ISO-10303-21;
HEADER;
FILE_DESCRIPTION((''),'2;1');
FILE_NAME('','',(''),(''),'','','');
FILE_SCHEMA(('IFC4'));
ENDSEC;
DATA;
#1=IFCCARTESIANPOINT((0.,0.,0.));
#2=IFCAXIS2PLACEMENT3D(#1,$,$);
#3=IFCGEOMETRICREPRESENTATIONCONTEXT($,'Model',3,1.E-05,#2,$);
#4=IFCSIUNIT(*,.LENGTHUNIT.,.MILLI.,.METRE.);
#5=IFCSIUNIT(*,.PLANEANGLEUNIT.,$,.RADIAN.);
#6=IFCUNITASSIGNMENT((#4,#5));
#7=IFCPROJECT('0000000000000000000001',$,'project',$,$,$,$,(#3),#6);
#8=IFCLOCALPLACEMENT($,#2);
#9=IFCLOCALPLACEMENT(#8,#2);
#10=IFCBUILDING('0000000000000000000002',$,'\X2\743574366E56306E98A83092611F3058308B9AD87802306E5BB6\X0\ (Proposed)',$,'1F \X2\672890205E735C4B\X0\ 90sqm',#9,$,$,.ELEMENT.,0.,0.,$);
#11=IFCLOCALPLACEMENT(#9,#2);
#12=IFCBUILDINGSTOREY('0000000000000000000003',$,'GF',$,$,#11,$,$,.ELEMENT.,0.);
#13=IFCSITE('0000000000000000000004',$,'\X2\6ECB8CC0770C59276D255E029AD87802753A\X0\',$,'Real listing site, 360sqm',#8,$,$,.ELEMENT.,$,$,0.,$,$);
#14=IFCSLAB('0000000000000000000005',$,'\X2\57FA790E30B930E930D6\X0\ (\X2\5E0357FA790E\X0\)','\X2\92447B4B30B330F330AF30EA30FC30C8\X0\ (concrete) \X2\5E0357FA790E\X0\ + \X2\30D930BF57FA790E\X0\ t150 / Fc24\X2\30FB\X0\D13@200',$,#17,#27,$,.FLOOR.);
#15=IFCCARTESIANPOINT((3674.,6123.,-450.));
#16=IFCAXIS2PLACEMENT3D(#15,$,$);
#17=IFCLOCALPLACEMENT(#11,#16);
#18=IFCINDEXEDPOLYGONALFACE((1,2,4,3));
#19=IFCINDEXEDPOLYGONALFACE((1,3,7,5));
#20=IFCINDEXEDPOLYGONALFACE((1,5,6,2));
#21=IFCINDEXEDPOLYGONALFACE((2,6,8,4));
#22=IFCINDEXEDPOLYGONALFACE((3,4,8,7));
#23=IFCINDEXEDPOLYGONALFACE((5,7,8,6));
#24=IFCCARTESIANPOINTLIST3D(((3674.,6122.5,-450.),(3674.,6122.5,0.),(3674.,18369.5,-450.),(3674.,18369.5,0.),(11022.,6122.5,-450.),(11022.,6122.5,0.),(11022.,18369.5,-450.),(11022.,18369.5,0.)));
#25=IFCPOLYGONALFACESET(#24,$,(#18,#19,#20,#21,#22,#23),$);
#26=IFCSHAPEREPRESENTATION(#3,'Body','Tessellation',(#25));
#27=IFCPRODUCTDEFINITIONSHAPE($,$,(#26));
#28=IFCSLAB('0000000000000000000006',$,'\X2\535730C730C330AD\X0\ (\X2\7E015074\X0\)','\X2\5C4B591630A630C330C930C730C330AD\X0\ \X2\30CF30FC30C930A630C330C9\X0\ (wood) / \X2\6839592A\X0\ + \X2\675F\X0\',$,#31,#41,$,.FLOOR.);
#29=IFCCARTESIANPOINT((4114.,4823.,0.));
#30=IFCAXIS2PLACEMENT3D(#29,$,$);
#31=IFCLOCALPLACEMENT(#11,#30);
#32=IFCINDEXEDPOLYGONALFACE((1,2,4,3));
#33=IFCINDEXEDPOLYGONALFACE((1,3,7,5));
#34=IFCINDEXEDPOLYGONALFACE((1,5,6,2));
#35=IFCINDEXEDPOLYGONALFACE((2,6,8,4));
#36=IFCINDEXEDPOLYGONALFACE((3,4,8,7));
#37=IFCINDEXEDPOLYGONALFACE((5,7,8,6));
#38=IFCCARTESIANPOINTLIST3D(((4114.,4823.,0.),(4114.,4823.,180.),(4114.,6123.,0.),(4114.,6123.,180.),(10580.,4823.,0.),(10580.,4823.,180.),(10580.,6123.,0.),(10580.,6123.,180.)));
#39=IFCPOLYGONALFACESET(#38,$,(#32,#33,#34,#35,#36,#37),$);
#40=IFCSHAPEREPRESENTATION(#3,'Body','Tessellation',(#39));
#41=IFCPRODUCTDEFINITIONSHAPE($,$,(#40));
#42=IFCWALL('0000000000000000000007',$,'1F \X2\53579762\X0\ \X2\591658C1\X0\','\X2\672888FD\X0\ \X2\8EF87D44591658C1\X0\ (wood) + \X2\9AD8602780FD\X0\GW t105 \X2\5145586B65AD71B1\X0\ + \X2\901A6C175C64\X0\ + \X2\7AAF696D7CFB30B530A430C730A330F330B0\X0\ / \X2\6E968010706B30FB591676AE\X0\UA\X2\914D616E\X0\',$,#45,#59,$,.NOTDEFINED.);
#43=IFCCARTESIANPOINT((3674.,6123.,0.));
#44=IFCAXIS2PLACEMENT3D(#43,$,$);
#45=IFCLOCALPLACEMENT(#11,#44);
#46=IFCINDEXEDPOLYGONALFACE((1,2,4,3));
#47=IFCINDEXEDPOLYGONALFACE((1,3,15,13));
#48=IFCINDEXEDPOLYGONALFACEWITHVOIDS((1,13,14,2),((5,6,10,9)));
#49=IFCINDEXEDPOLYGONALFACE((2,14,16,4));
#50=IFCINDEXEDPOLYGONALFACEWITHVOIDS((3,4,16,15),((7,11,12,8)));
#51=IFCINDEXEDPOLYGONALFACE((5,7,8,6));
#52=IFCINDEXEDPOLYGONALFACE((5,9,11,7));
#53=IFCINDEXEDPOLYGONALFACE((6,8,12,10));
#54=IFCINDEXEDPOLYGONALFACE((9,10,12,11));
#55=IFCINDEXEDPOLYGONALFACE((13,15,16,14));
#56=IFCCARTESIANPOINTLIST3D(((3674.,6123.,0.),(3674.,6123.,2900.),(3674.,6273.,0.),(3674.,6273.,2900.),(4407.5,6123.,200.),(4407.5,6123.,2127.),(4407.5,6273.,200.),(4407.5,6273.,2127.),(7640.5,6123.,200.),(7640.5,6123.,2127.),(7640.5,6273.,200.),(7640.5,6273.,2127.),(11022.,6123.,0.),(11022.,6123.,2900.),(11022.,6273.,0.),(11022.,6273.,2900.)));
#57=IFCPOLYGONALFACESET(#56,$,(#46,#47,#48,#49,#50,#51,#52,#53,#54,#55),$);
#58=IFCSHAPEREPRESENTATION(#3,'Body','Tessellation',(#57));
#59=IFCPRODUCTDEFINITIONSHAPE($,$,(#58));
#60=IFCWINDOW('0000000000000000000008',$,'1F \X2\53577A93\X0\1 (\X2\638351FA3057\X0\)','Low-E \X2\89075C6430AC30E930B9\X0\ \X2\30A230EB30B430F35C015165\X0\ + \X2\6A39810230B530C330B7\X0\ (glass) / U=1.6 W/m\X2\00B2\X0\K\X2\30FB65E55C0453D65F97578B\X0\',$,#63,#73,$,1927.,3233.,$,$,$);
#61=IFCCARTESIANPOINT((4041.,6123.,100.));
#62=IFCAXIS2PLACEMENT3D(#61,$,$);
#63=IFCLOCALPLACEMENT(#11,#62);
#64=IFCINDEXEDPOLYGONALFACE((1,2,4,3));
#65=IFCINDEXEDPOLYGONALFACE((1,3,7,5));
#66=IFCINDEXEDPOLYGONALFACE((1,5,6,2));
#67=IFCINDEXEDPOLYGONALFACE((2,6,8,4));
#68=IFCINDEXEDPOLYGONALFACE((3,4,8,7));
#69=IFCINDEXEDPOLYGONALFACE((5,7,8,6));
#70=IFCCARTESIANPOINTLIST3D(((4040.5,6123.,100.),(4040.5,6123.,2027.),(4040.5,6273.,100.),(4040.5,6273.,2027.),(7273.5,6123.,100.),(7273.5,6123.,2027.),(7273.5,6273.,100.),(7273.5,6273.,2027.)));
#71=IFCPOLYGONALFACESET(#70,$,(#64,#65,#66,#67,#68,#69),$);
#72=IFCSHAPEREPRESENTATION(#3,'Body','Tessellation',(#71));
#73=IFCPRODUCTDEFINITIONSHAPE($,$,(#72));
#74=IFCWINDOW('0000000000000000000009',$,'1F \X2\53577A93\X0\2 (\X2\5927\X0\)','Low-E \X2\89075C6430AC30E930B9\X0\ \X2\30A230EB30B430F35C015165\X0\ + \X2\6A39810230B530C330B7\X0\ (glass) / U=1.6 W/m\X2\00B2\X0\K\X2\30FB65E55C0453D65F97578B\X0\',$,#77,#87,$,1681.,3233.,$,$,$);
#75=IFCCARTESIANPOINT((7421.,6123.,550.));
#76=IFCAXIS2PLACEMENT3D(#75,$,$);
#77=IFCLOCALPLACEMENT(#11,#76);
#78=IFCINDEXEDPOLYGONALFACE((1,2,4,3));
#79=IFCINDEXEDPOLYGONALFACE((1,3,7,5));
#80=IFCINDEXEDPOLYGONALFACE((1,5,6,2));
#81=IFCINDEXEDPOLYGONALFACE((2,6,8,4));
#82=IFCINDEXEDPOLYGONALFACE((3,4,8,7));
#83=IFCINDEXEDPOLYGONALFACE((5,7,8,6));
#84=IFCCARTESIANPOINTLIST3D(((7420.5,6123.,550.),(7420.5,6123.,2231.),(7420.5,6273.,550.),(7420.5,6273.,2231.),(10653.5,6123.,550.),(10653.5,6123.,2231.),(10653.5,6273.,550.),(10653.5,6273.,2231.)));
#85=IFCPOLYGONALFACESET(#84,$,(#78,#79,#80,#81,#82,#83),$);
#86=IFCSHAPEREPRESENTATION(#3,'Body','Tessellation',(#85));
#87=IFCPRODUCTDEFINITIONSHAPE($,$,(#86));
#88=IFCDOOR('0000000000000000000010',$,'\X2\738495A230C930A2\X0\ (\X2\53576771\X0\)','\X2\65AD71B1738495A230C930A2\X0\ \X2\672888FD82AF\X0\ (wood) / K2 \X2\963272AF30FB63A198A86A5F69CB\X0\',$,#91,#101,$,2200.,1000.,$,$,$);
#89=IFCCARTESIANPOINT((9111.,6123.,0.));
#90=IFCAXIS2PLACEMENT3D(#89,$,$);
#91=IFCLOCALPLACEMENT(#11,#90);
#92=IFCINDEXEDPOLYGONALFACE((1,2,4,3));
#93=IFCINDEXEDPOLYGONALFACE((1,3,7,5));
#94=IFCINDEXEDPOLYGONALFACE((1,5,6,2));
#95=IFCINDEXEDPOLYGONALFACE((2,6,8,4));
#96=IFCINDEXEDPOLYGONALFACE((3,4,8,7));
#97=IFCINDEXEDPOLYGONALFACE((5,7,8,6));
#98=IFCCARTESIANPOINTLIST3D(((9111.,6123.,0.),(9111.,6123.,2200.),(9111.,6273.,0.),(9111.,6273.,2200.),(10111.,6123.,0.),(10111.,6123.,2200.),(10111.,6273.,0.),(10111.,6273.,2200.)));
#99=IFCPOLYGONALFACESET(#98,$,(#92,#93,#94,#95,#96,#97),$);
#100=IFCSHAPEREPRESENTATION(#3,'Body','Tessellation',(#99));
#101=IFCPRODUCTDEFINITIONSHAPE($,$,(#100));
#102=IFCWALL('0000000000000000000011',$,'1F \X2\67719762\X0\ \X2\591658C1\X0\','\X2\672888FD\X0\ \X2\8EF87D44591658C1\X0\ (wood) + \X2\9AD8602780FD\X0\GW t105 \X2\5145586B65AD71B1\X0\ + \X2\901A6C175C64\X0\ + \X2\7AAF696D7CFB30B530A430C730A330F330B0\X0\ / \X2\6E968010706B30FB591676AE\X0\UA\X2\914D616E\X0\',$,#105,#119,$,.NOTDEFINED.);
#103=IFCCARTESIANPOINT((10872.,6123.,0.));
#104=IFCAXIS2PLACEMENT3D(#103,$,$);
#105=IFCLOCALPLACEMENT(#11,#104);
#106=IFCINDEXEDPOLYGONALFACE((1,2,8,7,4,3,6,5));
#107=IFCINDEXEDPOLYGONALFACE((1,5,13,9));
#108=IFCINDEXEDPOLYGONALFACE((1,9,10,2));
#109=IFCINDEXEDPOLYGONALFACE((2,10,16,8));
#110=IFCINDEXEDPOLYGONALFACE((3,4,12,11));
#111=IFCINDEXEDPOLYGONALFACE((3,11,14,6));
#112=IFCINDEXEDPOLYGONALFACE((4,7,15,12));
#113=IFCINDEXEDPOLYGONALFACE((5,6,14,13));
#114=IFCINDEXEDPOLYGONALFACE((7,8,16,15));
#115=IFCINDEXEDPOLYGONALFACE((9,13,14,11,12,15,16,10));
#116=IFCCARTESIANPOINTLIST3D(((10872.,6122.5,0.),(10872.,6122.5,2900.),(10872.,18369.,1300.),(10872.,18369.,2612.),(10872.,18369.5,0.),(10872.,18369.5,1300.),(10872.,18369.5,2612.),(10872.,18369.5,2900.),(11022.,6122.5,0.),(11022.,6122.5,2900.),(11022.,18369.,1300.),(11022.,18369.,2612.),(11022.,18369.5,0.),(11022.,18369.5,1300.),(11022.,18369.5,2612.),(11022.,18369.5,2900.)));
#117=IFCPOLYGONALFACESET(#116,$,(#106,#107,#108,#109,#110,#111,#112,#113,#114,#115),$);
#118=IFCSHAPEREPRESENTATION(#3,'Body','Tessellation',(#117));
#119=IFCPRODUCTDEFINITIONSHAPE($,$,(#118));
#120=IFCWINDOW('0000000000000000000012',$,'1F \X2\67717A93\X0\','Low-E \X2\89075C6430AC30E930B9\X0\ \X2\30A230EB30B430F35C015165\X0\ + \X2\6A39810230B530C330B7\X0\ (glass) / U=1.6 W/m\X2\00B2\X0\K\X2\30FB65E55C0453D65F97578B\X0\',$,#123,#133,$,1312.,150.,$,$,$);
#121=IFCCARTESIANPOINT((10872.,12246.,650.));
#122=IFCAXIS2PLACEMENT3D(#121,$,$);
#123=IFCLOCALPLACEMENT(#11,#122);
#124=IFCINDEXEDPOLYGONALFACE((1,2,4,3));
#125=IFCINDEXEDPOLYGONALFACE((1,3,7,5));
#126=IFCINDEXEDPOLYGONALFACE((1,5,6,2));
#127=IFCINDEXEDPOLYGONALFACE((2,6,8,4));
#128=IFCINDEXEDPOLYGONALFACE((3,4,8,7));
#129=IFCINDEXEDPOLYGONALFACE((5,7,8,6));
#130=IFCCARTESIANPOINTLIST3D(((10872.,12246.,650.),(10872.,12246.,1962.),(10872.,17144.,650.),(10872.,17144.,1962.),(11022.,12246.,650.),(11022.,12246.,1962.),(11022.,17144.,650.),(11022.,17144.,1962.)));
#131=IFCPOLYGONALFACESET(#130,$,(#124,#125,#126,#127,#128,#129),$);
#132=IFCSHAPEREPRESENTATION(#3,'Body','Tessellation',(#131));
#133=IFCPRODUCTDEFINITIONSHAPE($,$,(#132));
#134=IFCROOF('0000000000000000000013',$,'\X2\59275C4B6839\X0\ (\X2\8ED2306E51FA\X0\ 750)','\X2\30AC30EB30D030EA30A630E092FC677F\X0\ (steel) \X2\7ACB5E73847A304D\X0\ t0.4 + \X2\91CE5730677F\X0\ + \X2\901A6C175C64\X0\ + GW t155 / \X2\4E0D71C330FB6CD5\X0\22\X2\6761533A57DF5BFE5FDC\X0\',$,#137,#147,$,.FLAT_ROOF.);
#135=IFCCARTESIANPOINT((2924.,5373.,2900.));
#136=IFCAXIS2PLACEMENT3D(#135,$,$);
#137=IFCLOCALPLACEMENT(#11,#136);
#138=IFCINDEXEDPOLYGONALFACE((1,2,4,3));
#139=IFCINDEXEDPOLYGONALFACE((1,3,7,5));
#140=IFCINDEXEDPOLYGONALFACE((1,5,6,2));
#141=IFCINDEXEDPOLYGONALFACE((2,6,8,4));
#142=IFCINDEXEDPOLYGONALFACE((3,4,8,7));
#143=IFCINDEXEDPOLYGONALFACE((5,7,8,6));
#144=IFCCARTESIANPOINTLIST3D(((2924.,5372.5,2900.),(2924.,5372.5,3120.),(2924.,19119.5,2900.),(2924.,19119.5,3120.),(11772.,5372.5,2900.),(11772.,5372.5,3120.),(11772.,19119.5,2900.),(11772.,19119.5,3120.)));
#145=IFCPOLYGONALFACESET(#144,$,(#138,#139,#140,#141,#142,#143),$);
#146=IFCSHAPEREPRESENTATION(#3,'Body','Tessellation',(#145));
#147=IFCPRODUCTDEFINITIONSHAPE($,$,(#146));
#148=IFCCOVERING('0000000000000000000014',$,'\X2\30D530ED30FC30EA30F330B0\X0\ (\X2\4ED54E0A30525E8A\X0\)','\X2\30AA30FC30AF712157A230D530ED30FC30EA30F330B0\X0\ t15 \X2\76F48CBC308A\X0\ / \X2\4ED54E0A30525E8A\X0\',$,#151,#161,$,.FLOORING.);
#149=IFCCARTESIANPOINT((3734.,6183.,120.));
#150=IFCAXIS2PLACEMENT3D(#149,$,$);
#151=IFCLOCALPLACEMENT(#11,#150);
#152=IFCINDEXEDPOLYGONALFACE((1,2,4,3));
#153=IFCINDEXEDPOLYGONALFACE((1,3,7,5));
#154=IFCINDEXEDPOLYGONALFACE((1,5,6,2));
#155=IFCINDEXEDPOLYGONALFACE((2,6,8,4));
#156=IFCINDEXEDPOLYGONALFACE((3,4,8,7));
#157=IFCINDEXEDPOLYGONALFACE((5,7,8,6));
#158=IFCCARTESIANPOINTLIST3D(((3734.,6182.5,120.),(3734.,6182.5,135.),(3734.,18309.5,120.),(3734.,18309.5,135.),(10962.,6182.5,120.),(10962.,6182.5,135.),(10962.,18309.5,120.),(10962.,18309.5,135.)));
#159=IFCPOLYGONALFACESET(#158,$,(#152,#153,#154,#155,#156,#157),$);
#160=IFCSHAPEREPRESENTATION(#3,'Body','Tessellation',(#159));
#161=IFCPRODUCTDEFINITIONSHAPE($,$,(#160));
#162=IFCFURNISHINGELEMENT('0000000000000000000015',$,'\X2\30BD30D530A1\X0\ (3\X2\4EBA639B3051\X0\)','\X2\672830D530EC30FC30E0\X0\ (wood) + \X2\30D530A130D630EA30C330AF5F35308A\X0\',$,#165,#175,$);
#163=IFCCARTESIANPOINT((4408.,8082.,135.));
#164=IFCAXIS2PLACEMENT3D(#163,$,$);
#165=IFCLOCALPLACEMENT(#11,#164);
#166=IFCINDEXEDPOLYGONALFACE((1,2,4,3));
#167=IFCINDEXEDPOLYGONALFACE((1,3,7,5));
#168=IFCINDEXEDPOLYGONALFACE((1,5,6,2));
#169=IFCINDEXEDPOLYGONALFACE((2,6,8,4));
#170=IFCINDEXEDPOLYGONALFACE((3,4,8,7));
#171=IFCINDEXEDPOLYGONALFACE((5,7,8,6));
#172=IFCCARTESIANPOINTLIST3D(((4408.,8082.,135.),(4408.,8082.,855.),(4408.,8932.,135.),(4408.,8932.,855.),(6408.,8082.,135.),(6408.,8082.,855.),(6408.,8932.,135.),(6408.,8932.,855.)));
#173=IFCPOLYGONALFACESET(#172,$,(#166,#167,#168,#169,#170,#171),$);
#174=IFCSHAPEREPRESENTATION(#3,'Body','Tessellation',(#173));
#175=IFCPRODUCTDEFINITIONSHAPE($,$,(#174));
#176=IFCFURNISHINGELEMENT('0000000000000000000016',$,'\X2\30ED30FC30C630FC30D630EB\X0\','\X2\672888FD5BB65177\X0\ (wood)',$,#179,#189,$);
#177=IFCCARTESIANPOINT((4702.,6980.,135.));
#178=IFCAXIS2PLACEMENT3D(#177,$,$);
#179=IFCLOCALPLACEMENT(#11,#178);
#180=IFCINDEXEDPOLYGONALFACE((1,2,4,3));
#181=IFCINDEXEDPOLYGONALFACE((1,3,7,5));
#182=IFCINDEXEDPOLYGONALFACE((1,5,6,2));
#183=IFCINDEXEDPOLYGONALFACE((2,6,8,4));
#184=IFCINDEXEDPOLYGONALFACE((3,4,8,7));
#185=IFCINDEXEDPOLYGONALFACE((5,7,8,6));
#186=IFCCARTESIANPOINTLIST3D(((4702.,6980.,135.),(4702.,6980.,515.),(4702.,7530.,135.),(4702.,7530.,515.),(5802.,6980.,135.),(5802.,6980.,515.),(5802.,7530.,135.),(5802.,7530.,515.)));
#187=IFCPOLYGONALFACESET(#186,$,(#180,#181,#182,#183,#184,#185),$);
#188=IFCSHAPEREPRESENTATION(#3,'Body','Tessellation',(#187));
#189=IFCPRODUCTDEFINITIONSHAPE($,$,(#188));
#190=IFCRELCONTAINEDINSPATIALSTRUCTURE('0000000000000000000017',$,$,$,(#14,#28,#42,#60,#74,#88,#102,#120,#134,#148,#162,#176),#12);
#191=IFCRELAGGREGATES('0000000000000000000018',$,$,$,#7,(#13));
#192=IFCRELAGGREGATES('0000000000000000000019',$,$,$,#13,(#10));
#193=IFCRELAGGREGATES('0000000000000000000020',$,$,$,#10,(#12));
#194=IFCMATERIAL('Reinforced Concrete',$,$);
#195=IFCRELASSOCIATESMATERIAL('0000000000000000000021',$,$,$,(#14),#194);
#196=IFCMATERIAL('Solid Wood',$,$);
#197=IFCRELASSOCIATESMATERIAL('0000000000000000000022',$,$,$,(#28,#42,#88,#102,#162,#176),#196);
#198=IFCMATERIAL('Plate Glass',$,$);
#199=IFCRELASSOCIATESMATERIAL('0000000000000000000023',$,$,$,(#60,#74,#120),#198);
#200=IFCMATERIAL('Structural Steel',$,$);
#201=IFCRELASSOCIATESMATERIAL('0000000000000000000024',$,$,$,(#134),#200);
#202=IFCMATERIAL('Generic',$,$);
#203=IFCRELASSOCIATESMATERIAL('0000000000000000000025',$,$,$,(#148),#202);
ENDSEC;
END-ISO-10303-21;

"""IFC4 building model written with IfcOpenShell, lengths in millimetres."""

from ifc_helpers import new_model, si_unit, frame, frame_2d, origin, place, context, project, spatial, rectangle, extrude, material, element, fill, save


model = new_model("IFC4")

# Units and contexts
model_context = context("Model", 3, precision=1e-05, world=origin())
ifc_project = project(units=[si_unit("LENGTHUNIT", "METRE", prefix="MILLI"), si_unit("PLANEANGLEUNIT", "RADIAN")], contexts=[model_context])

# Site, building, storey
site_placement = place(None, origin())
site = spatial("IfcSite", under=ifc_project, at=site_placement, Name="滋賀県大津市高砂町", ObjectType="Real listing site, 360sqm", CompositionType="ELEMENT", RefElevation=0.0)
building_placement = place(site_placement, origin())
building = spatial("IfcBuilding", under=site, at=building_placement, Name="琵琶湖の風を感じる高砂の家 (Proposed)", ObjectType="1F 木造平屋 90sqm", CompositionType="ELEMENT", ElevationOfRefHeight=0.0, ElevationOfTerrain=0.0)
storey_placement = place(building_placement, origin())
storey = spatial("IfcBuildingStorey", under=building, at=storey_placement, Name="GF", CompositionType="ELEMENT", Elevation=0.0)

# Slabs
ifc_material_1 = material(Name="Reinforced Concrete")
slab_1_placement = place(storey_placement, frame((3674.0, 6123.0, -450.0)))
element("IfcSlab", 1, at=slab_1_placement, inside=storey, material=ifc_material_1, Name="基礎スラブ (布基礎)", Description="鉄筋コンクリート (concrete) 布基礎 + ベタ基礎 t150 / Fc24・D13@200", PredefinedType="FLOOR", context=model_context, shape_type="SweptSolid", body=[
    extrude(rectangle(XDim=7348.0, YDim=12247.0, at=frame_2d((3674.0, 6123.0))), frame((3674.0, 6123.0, -450.0)), (0.0, 0.0, 1.0), 450.0),
])
ifc_material_2 = material(Name="Solid Wood")
slab_2_placement = place(storey_placement, frame((4114.0, 4823.0, 0.0)))
element("IfcSlab", 2, at=slab_2_placement, inside=storey, material=ifc_material_2, Name="南デッキ (縁側)", Description="屋外ウッドデッキ ハードウッド (wood) / 根太 + 束", PredefinedType="FLOOR", context=model_context, shape_type="SweptSolid", body=[
    extrude(rectangle(XDim=6466.0, YDim=1300.0, at=frame_2d((3233.0, 650.0))), frame((4114.0, 4823.0, 0.0)), (0.0, 0.0, 1.0), 180.0),
])

# Wall, openings, windows, door
wall_1_placement = place(storey_placement, frame((3674.0, 6123.0, 0.0)))
wall_1 = element("IfcWall", 3, at=wall_1_placement, inside=storey, material=ifc_material_2, Name="1F 南面 外壁", Description="木製 軸組外壁 (wood) + 高性能GW t105 充填断熱 + 通気層 + 窯業系サイディング / 準耐火・外皮UA配慮", PredefinedType="NOTDEFINED", context=model_context, shape_type="SweptSolid", body=[
    extrude(rectangle(XDim=7348.0, YDim=150.0, at=frame_2d((3674.0, 75.0))), frame((3674.0, 6123.0, 0.0)), (0.0, 0.0, 1.0), 2900.0),
])
opening_1_placement = place(storey_placement, frame((4041.0, 6123.0, 100.0)))
opening_1 = element("IfcOpeningElement", 4, at=opening_1_placement, cuts=wall_1, PredefinedType="NOTDEFINED", context=model_context, shape_type="SweptSolid", body=[
    extrude(rectangle(XDim=3233.0, YDim=150.0, at=frame_2d((1616.0, 75.0))), frame((4041.0, 6123.0, 100.0)), (0.0, 0.0, 1.0), 1927.0),
])
opening_2_placement = place(storey_placement, frame((7421.0, 6123.0, 550.0)))
opening_2 = element("IfcOpeningElement", 5, at=opening_2_placement, cuts=wall_1, PredefinedType="NOTDEFINED", context=model_context, shape_type="SweptSolid", body=[
    extrude(rectangle(XDim=3233.0, YDim=150.0, at=frame_2d((1616.0, 75.0))), frame((7421.0, 6123.0, 550.0)), (0.0, 0.0, 1.0), 1681.0),
])
opening_3_placement = place(storey_placement, frame((9111.0, 6123.0, 0.0)))
opening_3 = element("IfcOpeningElement", 6, at=opening_3_placement, cuts=wall_1, PredefinedType="NOTDEFINED", context=model_context, shape_type="SweptSolid", body=[
    extrude(rectangle(XDim=1000.0, YDim=150.0, at=frame_2d((500.0, 75.0))), frame((9111.0, 6123.0, 0.0)), (0.0, 0.0, 1.0), 2200.0),
])
ifc_material_3 = material(Name="Plate Glass")
window_1_placement = place(storey_placement, frame((4041.0, 6123.0, 100.0)))
window_1 = element("IfcWindow", 7, at=window_1_placement, inside=storey, material=ifc_material_3, Name="1F 南窓1 (掃出し)", Description="Low-E 複層ガラス アルゴン封入 + 樹脂サッシ (glass) / U=1.6 W/m²K・日射取得型", OverallHeight=1927.0, OverallWidth=3233.0, context=model_context, shape_type="SweptSolid", body=[
    extrude(rectangle(XDim=3233.0, YDim=150.0, at=frame_2d((1616.0, 75.0))), frame((4041.0, 6123.0, 100.0)), (0.0, 0.0, 1.0), 1927.0),
])
fill(opening_1, window_1)
window_2_placement = place(storey_placement, frame((7421.0, 6123.0, 550.0)))
window_2 = element("IfcWindow", 8, at=window_2_placement, inside=storey, material=ifc_material_3, Name="1F 南窓2 (大)", Description="Low-E 複層ガラス アルゴン封入 + 樹脂サッシ (glass) / U=1.6 W/m²K・日射取得型", OverallHeight=1681.0, OverallWidth=3233.0, context=model_context, shape_type="SweptSolid", body=[
    extrude(rectangle(XDim=3233.0, YDim=150.0, at=frame_2d((1616.0, 75.0))), frame((7421.0, 6123.0, 550.0)), (0.0, 0.0, 1.0), 1681.0),
])
fill(opening_2, window_2)
door_placement = place(storey_placement, frame((9111.0, 6123.0, 0.0)))
door = element("IfcDoor", 9, at=door_placement, inside=storey, material=ifc_material_2, Name="玄関ドア (南東)", Description="断熱玄関ドア 木製芯 (wood) / K2 防犯・採風機構", OverallHeight=2200.0, OverallWidth=1000.0, context=model_context, shape_type="SweptSolid", body=[
    extrude(rectangle(XDim=1000.0, YDim=150.0, at=frame_2d((500.0, 75.0))), frame((9111.0, 6123.0, 0.0)), (0.0, 0.0, 1.0), 2200.0),
])
fill(opening_3, door)

# Wall, opening, window
wall_2_placement = place(storey_placement, frame((10872.0, 6123.0, 0.0)))
wall_2 = element("IfcWall", 10, at=wall_2_placement, inside=storey, material=ifc_material_2, Name="1F 東面 外壁", Description="木製 軸組外壁 (wood) + 高性能GW t105 充填断熱 + 通気層 + 窯業系サイディング / 準耐火・外皮UA配慮", PredefinedType="NOTDEFINED", context=model_context, shape_type="SweptSolid", body=[
    extrude(rectangle(XDim=150.0, YDim=12247.0, at=frame_2d((75.0, 6123.0))), frame((10872.0, 6123.0, 0.0)), (0.0, 0.0, 1.0), 2900.0),
])
opening_4_placement = place(storey_placement, frame((10872.0, 12246.0, 650.0)))
opening_4 = element("IfcOpeningElement", 11, at=opening_4_placement, cuts=wall_2, PredefinedType="NOTDEFINED", context=model_context, shape_type="SweptSolid", body=[
    extrude(rectangle(XDim=150.0, YDim=4898.0, at=frame_2d((75.0, 2449.0))), frame((10872.0, 12246.0, 650.0)), (0.0, 0.0, 1.0), 1312.0),
])
window_3_placement = place(storey_placement, frame((10872.0, 12246.0, 650.0)))
window_3 = element("IfcWindow", 12, at=window_3_placement, inside=storey, material=ifc_material_3, Name="1F 東窓", Description="Low-E 複層ガラス アルゴン封入 + 樹脂サッシ (glass) / U=1.6 W/m²K・日射取得型", OverallHeight=1312.0, OverallWidth=150.0, context=model_context, shape_type="SweptSolid", body=[
    extrude(rectangle(XDim=150.0, YDim=4898.0, at=frame_2d((75.0, 2449.0))), frame((10872.0, 12246.0, 650.0)), (0.0, 0.0, 1.0), 1312.0),
])
fill(opening_4, window_3)

# Roof
ifc_material_4 = material(Name="Structural Steel")
roof_placement = place(storey_placement, frame((2924.0, 5373.0, 2900.0)))
element("IfcRoof", 13, at=roof_placement, inside=storey, material=ifc_material_4, Name="大屋根 (軒の出 750)", Description="ガルバリウム鋼板 (steel) 立平葺き t0.4 + 野地板 + 通気層 + GW t155 / 不燃・法22条区域対応", PredefinedType="FLAT_ROOF", context=model_context, shape_type="SweptSolid", body=[
    extrude(rectangle(XDim=8848.0, YDim=13747.0, at=frame_2d((4424.0, 6873.0))), frame((2924.0, 5373.0, 2900.0)), (0.0, 0.0, 1.0), 220.0),
])

# Covering
ifc_material_5 = material(Name="Generic")
covering_placement = place(storey_placement, frame((3734.0, 6183.0, 120.0)))
element("IfcCovering", 14, at=covering_placement, inside=storey, material=ifc_material_5, Name="フローリング (仕上げ床)", Description="オーク無垢フローリング t15 直貼り / 仕上げ床", PredefinedType="FLOORING", context=model_context, shape_type="SweptSolid", body=[
    extrude(rectangle(XDim=7228.0, YDim=12127.0, at=frame_2d((3614.0, 6063.0))), frame((3734.0, 6183.0, 120.0)), (0.0, 0.0, 1.0), 15.0),
])

# Furnishing elements
furnishing_1_placement = place(storey_placement, frame((4408.0, 8082.0, 135.0)))
element("IfcFurnishingElement", 15, at=furnishing_1_placement, inside=storey, material=ifc_material_2, Name="ソファ (3人掛け)", Description="木フレーム (wood) + ファブリック張り", context=model_context, shape_type="SweptSolid", body=[
    extrude(rectangle(XDim=2000.0, YDim=850.0, at=frame_2d((1000.0, 425.0))), frame((4408.0, 8082.0, 135.0)), (0.0, 0.0, 1.0), 720.0),
])
furnishing_2_placement = place(storey_placement, frame((4702.0, 6980.0, 135.0)))
element("IfcFurnishingElement", 16, at=furnishing_2_placement, inside=storey, material=ifc_material_2, Name="ローテーブル", Description="木製家具 (wood)", context=model_context, shape_type="SweptSolid", body=[
    extrude(rectangle(XDim=1100.0, YDim=550.0, at=frame_2d((550.0, 275.0))), frame((4702.0, 6980.0, 135.0)), (0.0, 0.0, 1.0), 380.0),
])

save(model, "model.ifc")
